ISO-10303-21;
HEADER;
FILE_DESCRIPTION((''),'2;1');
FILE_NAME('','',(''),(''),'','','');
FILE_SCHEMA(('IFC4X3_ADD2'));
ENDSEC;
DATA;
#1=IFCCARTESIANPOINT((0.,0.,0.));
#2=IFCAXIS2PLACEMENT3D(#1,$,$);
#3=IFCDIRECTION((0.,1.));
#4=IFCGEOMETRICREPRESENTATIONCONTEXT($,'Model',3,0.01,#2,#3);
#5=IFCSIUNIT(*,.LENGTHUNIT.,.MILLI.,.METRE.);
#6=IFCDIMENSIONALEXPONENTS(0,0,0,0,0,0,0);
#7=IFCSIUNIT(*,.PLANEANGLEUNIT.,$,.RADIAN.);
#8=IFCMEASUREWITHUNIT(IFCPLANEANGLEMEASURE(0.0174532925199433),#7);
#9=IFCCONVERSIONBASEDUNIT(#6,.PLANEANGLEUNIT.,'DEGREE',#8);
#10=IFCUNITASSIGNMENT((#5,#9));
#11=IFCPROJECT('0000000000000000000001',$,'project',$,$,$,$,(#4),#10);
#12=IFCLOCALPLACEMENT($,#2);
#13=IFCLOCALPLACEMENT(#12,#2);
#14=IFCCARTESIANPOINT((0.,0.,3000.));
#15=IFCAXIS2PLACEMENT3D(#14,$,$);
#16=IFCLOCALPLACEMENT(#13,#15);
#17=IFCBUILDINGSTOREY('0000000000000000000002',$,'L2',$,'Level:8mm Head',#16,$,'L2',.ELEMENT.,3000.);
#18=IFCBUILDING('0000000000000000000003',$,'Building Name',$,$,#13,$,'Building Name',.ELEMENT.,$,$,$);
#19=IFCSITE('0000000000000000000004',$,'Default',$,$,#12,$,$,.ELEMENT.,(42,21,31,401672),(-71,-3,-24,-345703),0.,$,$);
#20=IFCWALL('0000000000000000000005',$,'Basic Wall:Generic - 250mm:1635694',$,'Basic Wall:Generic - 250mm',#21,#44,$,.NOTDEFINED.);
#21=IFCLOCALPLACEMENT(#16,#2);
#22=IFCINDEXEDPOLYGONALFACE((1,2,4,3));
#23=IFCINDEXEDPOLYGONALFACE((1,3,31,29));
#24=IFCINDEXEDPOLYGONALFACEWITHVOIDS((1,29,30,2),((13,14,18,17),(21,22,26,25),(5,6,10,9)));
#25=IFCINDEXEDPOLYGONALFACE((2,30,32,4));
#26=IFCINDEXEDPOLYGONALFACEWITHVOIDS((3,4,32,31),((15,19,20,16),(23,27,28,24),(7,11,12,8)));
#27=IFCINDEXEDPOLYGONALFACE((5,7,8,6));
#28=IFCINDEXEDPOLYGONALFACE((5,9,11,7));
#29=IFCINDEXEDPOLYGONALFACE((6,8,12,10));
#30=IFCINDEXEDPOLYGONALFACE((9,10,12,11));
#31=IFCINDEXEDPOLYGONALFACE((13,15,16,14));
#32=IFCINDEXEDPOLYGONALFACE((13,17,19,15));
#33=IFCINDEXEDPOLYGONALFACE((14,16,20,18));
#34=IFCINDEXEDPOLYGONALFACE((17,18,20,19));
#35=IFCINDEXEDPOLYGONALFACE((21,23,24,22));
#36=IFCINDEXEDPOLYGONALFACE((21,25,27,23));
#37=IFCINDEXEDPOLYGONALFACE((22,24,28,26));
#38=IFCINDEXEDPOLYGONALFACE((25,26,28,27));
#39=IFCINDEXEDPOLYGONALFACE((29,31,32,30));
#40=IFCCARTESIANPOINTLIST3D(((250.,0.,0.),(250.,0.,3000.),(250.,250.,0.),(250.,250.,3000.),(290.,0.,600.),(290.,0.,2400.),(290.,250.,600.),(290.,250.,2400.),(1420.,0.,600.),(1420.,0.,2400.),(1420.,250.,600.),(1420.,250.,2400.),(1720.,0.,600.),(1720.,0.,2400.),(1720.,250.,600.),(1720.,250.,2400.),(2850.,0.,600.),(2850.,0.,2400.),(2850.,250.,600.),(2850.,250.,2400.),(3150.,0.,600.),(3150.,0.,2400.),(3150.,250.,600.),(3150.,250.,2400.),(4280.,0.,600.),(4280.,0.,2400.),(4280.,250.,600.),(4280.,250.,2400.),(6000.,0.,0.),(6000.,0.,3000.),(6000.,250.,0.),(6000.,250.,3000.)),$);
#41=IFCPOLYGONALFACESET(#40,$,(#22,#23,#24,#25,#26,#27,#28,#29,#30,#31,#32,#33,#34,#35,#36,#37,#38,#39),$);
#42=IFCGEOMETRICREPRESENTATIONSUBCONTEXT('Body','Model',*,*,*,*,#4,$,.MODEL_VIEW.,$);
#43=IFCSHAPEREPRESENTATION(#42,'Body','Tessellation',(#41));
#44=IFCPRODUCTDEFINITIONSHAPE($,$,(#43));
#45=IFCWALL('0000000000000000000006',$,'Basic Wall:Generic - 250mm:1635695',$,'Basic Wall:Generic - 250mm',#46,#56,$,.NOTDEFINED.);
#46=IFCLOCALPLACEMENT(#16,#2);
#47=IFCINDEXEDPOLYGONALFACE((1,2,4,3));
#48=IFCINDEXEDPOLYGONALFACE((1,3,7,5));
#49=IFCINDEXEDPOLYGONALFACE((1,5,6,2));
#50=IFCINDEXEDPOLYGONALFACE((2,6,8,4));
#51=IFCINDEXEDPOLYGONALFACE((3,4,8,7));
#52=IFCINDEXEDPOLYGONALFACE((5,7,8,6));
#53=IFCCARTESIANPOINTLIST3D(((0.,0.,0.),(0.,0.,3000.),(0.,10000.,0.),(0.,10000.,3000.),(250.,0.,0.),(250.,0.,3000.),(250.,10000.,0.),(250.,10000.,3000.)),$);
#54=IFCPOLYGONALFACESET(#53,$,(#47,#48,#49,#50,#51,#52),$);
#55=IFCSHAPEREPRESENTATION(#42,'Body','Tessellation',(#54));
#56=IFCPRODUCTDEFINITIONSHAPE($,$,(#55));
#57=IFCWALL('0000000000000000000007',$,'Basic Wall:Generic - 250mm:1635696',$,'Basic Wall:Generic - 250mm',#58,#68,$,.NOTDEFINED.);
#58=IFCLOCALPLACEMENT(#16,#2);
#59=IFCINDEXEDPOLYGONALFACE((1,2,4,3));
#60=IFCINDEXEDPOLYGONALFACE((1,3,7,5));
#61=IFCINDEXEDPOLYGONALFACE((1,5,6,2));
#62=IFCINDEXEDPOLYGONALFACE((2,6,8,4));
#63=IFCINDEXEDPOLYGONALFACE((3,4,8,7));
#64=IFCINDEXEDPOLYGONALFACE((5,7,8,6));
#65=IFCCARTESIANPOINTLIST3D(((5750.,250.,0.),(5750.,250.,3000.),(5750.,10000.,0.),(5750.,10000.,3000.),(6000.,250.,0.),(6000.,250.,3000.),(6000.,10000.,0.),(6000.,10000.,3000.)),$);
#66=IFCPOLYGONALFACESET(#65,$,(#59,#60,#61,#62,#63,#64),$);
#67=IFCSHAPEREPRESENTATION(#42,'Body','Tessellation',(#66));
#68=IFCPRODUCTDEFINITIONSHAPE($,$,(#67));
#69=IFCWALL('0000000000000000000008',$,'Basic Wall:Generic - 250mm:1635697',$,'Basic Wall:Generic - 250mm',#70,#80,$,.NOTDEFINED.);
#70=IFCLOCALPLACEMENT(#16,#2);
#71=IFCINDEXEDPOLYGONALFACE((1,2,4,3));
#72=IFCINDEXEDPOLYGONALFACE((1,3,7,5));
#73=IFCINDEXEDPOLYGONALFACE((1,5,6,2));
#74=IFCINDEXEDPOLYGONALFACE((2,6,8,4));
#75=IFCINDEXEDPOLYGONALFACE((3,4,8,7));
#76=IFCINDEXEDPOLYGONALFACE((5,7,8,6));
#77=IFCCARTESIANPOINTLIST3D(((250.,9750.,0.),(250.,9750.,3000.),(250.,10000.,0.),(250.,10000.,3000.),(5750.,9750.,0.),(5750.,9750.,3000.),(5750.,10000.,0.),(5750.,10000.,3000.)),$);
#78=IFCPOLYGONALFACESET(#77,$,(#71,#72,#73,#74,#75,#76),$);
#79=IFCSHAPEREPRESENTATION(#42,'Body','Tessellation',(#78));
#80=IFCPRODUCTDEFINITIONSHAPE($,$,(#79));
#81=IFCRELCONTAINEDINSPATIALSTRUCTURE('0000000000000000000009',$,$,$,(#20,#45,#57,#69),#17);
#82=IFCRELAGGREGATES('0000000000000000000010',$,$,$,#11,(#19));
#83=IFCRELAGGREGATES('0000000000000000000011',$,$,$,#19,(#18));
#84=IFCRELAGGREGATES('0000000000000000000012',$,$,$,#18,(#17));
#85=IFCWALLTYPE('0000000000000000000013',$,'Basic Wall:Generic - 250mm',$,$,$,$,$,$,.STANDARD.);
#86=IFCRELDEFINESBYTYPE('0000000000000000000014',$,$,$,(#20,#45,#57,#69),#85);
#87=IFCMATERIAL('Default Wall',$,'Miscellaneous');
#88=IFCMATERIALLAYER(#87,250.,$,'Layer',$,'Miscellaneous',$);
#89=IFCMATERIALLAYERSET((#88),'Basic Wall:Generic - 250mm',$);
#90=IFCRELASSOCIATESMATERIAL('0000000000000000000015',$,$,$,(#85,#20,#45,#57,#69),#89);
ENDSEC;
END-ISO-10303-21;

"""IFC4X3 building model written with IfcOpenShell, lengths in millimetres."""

from ifc_helpers import new_model, entity, si_unit, converted_unit, direction, frame, frame_2d, origin, place, context, subcontext, project, spatial, rectangle, extrude, material, layer, layer_set, type_object, element, save


model = new_model("IFC4X3")

# Units and contexts
model_context = context("Model", 3, precision=0.01, world=origin(), true_north=direction((0.0, 1.0)))
body_context = subcontext(model_context, "Body", "Model", "MODEL_VIEW")
ifc_project = project(units=[si_unit("LENGTHUNIT", "METRE", prefix="MILLI"), converted_unit("PLANEANGLEUNIT", "DEGREE", entity("IfcPlaneAngleMeasure", 0.0174532925199433), si_unit("PLANEANGLEUNIT", "RADIAN"), dimensions=[0, 0, 0, 0, 0, 0, 0])], contexts=[model_context])

# Site, building, storey
site_placement = place(None, origin())
site = spatial("IfcSite", under=ifc_project, at=site_placement, Name="Default", CompositionType="ELEMENT", RefLatitude=(42, 21, 31, 401672), RefLongitude=(-71, -3, -24, -345703), RefElevation=0.0)
building_placement = place(site_placement, origin())
building = spatial("IfcBuilding", under=site, at=building_placement, Name="Building Name", LongName="Building Name", CompositionType="ELEMENT")
storey_placement = place(building_placement, frame((0.0, 0.0, 3000.0)))
storey = spatial("IfcBuildingStorey", under=building, at=storey_placement, Name="L2", ObjectType="Level:8mm Head", LongName="L2", CompositionType="ELEMENT", Elevation=3000.0)

# Wall, openings
ifc_material = material(Name="Default Wall", Category="Miscellaneous")
ifc_layer = layer(ifc_material, 250.0, Name="Layer", Category="Miscellaneous")
ifc_layer_set = layer_set([ifc_layer], Name="Basic Wall:Generic - 250mm")
wall_type = type_object("IfcWallType", Name="Basic Wall:Generic - 250mm", PredefinedType="STANDARD", material=ifc_layer_set)
wall_1_placement = place(storey_placement, frame((250.0, 125.0, 0.0)))
wall_1 = element("IfcWall", 1, at=wall_1_placement, inside=storey, type_object=wall_type, material=ifc_layer_set, Name="Basic Wall:Generic - 250mm:1635694", ObjectType="Basic Wall:Generic - 250mm", PredefinedType="NOTDEFINED", context=body_context, shape_type="SweptSolid", body=[
    extrude(rectangle(XDim=5750.0, YDim=250.0, at=frame_2d((2875.0, 0.0), x_axis=(-1.0, 0.0))), origin(), (0.0, 0.0, 1.0), 3000.0),
])
opening_1_placement = place(wall_1_placement, frame((40.0, -125.0, 600.0)))
element("IfcOpeningElement", 2, at=opening_1_placement, cuts=wall_1, PredefinedType="OPENING", context=body_context, shape_type="SweptSolid", body=[
    extrude(rectangle(XDim=1800.0, YDim=1130.0, at=frame_2d((900.0, 565.0), x_axis=(-1.0, 0.0))), frame((0.0, 0.0, 0.0), z_axis=(0.0, 1.0, 0.0), x_axis=(0.0, 0.0, 1.0)), (0.0, 0.0, 1.0), 250.0),
])
opening_2_placement = place(wall_1_placement, frame((2900.0, -125.0, 600.0)))
element("IfcOpeningElement", 3, at=opening_2_placement, cuts=wall_1, PredefinedType="OPENING", context=body_context, shape_type="SweptSolid", body=[
    extrude(rectangle(XDim=1800.0, YDim=1130.0, at=frame_2d((900.0, 565.0), x_axis=(-1.0, 0.0))), frame((0.0, 0.0, 0.0), z_axis=(0.0, 1.0, 0.0), x_axis=(0.0, 0.0, 1.0)), (0.0, 0.0, 1.0), 250.0),
])
opening_3_placement = place(wall_1_placement, frame((1470.0, -125.0, 600.0)))
element("IfcOpeningElement", 4, at=opening_3_placement, cuts=wall_1, PredefinedType="OPENING", context=body_context, shape_type="SweptSolid", body=[
    extrude(rectangle(XDim=1800.0, YDim=1130.0, at=frame_2d((900.0, 565.0), x_axis=(-1.0, 0.0))), frame((0.0, 0.0, 0.0), z_axis=(0.0, 1.0, 0.0), x_axis=(0.0, 0.0, 1.0)), (0.0, 0.0, 1.0), 250.0),
])

# Walls
wall_2_placement = place(storey_placement, frame((125.0, 10000.0, 0.0), z_axis=(0.0, 0.0, 1.0), x_axis=(0.0, -1.0, 0.0)))
element("IfcWall", 5, at=wall_2_placement, inside=storey, type_object=wall_type, material=ifc_layer_set, Name="Basic Wall:Generic - 250mm:1635695", ObjectType="Basic Wall:Generic - 250mm", PredefinedType="NOTDEFINED", context=body_context, shape_type="SweptSolid", body=[
    extrude(rectangle(XDim=10000.0, YDim=250.0, at=frame_2d((5000.0, 0.0), x_axis=(-1.0, 0.0))), origin(), (0.0, 0.0, 1.0), 3000.0),
])
wall_3_placement = place(storey_placement, frame((5875.0, 250.0, 0.0), z_axis=(0.0, 0.0, 1.0), x_axis=(0.0, 1.0, 0.0)))
element("IfcWall", 6, at=wall_3_placement, inside=storey, type_object=wall_type, material=ifc_layer_set, Name="Basic Wall:Generic - 250mm:1635696", ObjectType="Basic Wall:Generic - 250mm", PredefinedType="NOTDEFINED", context=body_context, shape_type="SweptSolid", body=[
    extrude(rectangle(XDim=9750.0, YDim=250.0, at=frame_2d((4875.0, 0.0), x_axis=(-1.0, 0.0))), origin(), (0.0, 0.0, 1.0), 3000.0),
])
wall_4_placement = place(storey_placement, frame((5750.0, 9875.0, 0.0), z_axis=(0.0, 0.0, 1.0), x_axis=(-1.0, 0.0, 0.0)))
element("IfcWall", 7, at=wall_4_placement, inside=storey, type_object=wall_type, material=ifc_layer_set, Name="Basic Wall:Generic - 250mm:1635697", ObjectType="Basic Wall:Generic - 250mm", PredefinedType="NOTDEFINED", context=body_context, shape_type="SweptSolid", body=[
    extrude(rectangle(XDim=5500.0, YDim=250.0, at=frame_2d((2750.0, 0.0), x_axis=(-1.0, 0.0))), origin(), (0.0, 0.0, 1.0), 3000.0),
])

save(model, "model.ifc")
